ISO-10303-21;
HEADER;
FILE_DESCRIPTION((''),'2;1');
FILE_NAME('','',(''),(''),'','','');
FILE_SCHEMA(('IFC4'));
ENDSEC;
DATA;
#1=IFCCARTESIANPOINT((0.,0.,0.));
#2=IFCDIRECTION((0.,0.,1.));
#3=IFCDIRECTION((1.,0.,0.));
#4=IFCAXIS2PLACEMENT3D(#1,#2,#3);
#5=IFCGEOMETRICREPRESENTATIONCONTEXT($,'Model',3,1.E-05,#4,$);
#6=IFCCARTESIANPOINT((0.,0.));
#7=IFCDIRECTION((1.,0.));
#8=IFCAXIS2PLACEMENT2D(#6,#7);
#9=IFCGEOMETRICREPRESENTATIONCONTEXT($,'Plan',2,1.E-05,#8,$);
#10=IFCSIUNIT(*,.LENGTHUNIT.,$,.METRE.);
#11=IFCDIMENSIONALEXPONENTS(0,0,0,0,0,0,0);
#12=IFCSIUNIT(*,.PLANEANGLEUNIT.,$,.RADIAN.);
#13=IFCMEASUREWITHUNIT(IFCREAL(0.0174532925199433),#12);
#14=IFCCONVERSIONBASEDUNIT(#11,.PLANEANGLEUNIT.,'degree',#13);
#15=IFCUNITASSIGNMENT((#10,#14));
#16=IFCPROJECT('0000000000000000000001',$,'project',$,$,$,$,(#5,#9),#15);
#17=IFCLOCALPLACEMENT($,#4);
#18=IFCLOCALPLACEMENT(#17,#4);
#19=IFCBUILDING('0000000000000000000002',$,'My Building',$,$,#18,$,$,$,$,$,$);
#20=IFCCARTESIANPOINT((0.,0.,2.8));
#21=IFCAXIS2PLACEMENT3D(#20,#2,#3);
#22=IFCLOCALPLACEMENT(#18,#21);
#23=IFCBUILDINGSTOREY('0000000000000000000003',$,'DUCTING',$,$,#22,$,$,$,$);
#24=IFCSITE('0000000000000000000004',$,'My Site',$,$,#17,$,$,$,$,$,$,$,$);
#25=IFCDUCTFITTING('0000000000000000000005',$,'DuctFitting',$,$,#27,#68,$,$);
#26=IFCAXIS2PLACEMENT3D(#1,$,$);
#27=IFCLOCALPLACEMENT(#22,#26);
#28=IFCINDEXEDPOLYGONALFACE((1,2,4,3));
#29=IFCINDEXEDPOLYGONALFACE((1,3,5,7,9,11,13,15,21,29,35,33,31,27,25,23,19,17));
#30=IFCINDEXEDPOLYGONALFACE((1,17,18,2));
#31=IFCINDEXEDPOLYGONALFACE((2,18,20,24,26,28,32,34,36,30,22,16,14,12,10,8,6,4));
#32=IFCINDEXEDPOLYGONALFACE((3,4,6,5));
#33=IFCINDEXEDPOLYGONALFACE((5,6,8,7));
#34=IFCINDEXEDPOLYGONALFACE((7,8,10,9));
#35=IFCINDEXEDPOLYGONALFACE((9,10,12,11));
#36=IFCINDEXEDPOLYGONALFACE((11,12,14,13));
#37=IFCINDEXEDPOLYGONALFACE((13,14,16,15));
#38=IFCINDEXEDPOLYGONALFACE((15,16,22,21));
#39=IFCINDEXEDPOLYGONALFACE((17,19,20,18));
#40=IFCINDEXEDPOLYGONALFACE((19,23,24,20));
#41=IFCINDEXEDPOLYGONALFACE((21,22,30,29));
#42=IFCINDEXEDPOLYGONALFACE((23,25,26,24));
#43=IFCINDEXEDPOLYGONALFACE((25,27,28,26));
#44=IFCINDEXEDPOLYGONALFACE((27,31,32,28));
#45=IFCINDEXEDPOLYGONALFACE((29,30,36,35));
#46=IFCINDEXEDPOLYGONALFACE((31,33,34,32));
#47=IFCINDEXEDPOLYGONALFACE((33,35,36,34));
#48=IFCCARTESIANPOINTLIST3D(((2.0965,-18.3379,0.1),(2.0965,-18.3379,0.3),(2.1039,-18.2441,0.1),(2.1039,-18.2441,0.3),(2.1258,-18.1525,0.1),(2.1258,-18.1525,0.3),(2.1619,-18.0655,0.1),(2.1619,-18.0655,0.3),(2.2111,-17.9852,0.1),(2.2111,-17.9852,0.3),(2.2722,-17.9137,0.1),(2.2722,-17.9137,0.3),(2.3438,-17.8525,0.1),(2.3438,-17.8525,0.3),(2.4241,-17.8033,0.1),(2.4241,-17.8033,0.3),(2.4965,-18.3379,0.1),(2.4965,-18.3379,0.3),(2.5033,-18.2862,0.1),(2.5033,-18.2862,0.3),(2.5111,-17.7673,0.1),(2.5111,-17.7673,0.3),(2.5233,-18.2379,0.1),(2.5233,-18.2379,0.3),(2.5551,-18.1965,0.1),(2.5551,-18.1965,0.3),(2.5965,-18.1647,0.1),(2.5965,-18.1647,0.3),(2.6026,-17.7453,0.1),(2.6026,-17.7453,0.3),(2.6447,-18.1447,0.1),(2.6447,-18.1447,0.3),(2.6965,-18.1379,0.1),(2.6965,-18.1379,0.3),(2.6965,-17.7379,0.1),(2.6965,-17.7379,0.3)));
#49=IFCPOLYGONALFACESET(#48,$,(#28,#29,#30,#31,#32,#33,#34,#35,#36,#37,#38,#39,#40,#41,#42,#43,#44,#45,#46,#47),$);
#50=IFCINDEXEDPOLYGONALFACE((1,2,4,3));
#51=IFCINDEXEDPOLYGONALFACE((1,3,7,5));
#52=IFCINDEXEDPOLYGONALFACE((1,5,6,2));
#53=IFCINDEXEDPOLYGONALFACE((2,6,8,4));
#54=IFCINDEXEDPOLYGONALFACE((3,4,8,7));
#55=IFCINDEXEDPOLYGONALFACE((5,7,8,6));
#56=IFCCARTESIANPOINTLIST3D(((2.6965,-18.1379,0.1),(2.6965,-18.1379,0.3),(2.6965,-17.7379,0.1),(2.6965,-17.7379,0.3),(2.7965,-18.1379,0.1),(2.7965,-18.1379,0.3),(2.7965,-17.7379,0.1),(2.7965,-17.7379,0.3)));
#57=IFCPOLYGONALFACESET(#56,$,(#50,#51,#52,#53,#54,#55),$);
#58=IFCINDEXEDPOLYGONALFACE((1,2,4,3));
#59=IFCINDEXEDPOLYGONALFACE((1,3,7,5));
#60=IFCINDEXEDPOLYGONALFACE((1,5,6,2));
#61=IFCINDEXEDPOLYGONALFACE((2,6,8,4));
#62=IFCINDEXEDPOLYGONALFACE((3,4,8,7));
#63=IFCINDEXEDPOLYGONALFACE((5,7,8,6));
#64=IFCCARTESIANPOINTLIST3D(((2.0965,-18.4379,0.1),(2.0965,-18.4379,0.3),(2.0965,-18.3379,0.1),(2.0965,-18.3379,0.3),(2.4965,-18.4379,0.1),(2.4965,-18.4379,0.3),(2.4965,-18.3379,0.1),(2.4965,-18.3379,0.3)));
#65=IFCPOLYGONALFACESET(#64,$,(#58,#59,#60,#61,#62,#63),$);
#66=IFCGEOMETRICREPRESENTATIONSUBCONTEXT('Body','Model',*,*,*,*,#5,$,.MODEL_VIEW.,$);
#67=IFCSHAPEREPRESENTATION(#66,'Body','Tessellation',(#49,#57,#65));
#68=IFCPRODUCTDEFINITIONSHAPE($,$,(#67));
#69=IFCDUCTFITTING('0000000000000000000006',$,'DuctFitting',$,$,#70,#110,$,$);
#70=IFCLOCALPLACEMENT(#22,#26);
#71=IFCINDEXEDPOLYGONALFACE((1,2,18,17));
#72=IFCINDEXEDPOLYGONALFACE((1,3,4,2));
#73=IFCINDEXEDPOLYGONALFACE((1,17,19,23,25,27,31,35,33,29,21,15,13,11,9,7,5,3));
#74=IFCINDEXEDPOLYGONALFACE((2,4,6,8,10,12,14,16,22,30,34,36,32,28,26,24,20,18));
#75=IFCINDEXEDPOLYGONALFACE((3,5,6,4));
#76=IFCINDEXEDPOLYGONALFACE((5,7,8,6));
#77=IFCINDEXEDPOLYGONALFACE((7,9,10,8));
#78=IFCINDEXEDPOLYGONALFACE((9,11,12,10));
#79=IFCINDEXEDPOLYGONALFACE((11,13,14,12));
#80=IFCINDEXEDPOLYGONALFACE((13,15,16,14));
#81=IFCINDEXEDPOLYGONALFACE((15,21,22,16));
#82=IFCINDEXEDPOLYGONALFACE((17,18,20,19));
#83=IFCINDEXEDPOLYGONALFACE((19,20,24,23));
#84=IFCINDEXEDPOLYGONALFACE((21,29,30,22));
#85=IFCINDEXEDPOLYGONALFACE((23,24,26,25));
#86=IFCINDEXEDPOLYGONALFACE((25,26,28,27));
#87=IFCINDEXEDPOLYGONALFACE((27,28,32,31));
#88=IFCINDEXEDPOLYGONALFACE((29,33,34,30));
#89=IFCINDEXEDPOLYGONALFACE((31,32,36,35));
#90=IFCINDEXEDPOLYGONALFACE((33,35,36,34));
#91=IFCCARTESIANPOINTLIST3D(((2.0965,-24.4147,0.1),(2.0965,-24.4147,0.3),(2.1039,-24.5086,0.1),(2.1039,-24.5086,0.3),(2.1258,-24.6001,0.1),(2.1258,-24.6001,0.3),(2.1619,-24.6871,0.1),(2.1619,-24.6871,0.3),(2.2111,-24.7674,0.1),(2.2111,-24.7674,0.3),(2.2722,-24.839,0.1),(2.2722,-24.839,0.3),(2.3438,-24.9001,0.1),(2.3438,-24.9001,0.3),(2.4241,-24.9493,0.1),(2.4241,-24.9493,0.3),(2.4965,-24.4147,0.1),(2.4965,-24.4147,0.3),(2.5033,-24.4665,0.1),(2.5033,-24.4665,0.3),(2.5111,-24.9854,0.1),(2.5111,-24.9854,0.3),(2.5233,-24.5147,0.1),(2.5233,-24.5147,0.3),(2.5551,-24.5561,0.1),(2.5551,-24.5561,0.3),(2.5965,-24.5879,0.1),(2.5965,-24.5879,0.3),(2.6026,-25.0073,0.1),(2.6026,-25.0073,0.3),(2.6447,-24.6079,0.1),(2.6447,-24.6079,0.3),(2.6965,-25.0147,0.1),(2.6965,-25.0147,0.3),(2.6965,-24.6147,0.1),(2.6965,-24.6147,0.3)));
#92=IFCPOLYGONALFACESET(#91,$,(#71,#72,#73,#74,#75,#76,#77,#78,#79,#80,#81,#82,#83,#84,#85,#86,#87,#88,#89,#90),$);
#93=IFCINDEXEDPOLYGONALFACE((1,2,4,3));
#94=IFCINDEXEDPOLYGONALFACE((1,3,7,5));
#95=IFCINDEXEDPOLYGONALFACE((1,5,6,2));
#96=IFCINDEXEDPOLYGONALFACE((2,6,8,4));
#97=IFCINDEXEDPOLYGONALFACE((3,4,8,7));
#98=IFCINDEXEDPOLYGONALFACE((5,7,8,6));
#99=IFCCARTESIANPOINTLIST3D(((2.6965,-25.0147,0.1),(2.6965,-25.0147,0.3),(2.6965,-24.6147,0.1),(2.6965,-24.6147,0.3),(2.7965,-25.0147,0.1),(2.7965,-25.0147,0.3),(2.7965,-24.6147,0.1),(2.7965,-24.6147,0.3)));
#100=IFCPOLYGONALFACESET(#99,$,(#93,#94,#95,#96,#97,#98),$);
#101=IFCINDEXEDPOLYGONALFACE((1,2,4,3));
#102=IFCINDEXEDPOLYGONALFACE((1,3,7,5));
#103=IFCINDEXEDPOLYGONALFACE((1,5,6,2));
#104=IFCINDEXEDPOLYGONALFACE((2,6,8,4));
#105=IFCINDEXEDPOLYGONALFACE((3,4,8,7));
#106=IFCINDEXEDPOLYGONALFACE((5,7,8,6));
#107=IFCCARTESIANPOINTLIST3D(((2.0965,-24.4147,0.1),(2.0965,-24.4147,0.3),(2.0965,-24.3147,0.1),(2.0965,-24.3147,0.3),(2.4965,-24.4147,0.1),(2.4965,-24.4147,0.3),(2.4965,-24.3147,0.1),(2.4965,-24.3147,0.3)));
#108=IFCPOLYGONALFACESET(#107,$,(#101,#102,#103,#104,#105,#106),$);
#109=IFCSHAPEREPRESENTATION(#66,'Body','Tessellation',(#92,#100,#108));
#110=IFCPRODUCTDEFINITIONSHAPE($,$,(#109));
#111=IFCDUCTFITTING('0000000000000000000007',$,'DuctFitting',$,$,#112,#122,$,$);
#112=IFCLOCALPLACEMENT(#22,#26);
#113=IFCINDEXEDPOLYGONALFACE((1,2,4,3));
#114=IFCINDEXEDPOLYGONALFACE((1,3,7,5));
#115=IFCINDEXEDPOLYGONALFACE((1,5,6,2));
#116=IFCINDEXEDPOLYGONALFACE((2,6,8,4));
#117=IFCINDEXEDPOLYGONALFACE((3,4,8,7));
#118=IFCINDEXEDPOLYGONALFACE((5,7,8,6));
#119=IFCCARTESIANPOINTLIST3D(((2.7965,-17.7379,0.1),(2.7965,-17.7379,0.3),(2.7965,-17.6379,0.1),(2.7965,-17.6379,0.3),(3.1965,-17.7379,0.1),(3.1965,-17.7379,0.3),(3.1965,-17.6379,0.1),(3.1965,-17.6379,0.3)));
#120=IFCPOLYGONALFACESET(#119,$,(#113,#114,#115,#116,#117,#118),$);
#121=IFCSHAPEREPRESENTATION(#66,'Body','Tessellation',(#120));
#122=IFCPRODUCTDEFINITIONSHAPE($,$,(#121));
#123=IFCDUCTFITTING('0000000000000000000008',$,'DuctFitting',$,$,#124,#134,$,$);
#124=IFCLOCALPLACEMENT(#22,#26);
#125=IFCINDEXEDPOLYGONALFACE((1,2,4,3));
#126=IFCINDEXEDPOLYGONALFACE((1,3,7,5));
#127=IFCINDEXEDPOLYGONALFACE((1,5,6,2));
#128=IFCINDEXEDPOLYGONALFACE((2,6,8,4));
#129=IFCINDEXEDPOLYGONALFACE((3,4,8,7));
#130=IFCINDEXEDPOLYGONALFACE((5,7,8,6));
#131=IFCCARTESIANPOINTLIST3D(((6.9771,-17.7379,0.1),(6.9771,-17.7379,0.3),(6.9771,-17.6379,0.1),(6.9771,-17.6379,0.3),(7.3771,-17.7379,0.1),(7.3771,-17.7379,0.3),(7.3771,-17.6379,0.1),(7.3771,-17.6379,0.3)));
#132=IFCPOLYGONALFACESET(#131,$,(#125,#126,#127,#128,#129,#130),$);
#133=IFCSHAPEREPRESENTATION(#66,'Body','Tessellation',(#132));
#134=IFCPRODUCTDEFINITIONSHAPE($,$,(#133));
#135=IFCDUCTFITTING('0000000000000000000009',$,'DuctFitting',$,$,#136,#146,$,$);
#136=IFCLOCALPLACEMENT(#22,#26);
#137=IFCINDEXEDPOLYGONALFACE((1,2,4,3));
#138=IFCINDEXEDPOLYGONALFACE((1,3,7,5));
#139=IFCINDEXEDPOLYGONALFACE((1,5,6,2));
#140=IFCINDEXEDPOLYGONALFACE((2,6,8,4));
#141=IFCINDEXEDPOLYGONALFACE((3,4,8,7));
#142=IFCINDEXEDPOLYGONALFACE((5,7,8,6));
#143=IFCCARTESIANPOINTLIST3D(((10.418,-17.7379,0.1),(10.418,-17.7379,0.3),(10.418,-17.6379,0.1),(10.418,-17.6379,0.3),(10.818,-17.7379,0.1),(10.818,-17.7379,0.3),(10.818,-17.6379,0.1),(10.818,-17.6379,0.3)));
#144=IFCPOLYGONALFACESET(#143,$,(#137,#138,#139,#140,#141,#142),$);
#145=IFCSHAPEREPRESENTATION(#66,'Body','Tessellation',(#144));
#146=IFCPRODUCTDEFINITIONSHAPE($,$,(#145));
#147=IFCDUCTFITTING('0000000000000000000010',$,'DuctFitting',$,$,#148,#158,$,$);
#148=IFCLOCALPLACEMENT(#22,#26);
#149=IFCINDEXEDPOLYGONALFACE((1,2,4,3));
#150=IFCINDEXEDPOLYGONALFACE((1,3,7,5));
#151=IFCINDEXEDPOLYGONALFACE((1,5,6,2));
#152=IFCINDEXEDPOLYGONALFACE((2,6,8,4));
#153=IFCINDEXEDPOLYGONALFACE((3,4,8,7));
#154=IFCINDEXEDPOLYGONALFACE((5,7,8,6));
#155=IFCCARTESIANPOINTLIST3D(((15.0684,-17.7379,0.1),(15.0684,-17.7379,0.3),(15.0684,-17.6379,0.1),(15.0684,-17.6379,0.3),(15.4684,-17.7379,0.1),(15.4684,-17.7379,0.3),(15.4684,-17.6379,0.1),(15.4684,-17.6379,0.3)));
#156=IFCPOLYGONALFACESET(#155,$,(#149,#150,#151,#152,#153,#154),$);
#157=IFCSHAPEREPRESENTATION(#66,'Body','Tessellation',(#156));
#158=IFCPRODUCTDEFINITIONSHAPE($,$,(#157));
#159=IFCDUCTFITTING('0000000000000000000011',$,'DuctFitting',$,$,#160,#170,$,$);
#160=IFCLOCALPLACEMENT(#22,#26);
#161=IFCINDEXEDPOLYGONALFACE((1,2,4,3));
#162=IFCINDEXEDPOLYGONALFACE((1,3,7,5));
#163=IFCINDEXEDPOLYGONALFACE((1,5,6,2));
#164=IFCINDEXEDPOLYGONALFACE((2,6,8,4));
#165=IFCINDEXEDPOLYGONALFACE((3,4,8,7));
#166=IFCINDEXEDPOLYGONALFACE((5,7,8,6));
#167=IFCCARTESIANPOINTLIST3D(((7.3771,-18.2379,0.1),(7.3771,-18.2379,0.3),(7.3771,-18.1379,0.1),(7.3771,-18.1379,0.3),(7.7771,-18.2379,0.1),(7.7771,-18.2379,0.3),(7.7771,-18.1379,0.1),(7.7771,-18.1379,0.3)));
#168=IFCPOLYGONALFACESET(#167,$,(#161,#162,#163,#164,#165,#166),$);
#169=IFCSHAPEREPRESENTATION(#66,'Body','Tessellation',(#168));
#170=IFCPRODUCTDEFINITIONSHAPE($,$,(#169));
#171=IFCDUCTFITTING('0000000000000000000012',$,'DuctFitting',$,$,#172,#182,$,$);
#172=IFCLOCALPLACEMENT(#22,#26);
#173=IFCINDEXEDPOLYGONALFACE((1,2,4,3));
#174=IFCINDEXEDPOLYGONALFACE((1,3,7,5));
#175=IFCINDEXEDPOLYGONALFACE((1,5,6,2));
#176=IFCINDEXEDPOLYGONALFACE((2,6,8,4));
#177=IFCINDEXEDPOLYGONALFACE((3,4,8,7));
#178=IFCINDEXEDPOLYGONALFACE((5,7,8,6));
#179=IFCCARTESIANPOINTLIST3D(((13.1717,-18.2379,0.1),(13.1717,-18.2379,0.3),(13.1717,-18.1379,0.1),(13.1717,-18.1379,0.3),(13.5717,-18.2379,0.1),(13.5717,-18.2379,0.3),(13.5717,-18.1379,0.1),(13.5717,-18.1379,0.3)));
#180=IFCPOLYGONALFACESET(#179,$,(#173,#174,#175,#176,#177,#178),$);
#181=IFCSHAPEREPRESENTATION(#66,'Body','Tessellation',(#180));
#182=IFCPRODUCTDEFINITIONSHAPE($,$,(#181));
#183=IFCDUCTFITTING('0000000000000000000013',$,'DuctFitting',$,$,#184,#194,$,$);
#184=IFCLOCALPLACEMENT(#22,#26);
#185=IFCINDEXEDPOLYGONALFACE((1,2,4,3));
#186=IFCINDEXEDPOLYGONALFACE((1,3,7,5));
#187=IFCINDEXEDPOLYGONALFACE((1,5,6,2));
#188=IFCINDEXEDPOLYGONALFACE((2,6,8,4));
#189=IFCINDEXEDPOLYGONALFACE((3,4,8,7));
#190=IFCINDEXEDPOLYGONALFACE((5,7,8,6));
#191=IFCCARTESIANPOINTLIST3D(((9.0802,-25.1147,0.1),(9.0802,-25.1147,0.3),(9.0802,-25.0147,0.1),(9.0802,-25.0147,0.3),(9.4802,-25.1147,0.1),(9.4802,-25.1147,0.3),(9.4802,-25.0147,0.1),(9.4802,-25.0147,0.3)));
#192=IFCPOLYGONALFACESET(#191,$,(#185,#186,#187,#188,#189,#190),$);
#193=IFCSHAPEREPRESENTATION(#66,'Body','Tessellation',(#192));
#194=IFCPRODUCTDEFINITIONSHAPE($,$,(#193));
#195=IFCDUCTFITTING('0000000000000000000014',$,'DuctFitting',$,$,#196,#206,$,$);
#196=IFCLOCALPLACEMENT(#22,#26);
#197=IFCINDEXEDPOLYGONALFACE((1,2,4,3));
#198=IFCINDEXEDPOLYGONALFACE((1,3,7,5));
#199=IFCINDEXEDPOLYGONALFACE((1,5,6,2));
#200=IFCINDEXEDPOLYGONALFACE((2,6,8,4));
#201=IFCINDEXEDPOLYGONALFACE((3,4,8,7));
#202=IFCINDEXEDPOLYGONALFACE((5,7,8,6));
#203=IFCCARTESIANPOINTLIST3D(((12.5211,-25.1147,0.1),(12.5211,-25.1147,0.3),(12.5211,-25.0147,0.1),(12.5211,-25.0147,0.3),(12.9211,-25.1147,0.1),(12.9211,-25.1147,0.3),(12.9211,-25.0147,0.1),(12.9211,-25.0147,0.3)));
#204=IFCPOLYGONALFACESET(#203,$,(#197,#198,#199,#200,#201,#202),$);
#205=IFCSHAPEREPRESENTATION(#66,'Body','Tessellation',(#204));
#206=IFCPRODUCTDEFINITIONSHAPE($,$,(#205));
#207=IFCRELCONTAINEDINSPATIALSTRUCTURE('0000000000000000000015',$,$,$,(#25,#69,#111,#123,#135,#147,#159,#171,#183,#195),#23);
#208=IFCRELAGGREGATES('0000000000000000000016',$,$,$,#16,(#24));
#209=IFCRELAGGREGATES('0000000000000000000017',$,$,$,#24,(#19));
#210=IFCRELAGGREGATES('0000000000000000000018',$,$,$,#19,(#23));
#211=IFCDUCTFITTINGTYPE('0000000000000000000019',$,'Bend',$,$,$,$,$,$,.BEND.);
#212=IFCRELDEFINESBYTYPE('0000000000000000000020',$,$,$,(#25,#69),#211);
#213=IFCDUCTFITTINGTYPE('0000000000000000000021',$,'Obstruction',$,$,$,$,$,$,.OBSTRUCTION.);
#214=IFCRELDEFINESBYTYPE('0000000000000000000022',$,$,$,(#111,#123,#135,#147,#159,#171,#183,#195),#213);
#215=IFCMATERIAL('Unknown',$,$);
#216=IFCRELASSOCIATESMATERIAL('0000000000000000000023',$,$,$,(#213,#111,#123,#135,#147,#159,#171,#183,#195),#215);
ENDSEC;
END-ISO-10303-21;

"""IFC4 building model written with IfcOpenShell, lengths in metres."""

from ifc_helpers import new_model, entity, si_unit, converted_unit, frame, origin_with_axes, origin_2d_with_axis, place, context, subcontext, project, spatial, line, arc, indexed_curve, rectangle, outline, extrude, source, transform, mapped, material, material_profile, profile_set, profile_usage, type_object, type_shapes, element, save


model = new_model("IFC4")

# Units and contexts
model_context = context("Model", 3, precision=1e-05, world=origin_with_axes())
plan_context = context("Plan", 2, precision=1e-05, world=origin_2d_with_axis())
body_context = subcontext(model_context, "Body", "Model", "MODEL_VIEW")
ifc_project = project(units=[si_unit("LENGTHUNIT", "METRE"), converted_unit("PLANEANGLEUNIT", "degree", entity("IfcReal", 0.0174532925199433), si_unit("PLANEANGLEUNIT", "RADIAN"), dimensions=[0, 0, 0, 0, 0, 0, 0])], contexts=[model_context, plan_context])

# Site, building, storey
site_placement = place(None, origin_with_axes())
site = spatial("IfcSite", under=ifc_project, at=site_placement, Name="My Site")
building_placement = place(site_placement, origin_with_axes())
building = spatial("IfcBuilding", under=site, at=building_placement, Name="My Building")
storey_placement = place(building_placement, frame((0.0, 0.0, 2.8), z_axis=(0.0, 0.0, 1.0), x_axis=(1.0, 0.0, 0.0)))
storey = spatial("IfcBuildingStorey", under=building, at=storey_placement, Name="DUCTING")

# Shared definitions
ifc_material = material(Name="Unknown")

# Duct fittings
duct_fitting_type_1 = type_object("IfcDuctFittingType", Name="Bend", PredefinedType="BEND")
shared_shape = source(origin_with_axes(), body_context, "Body", "SweptSolid", [
    extrude(outline(indexed_curve([(-0.2, 0.0), (-0.2586, -0.1414), (-0.4, -0.2), (-0.4, -0.6), (0.0243, -0.4243), (0.2, 0.0)], segments=[arc(1, 2, 3), line(3, 4), arc(4, 5, 6), line(6, 1)])), frame((0.0, -0.1, -0.1), z_axis=(0.0, -1.0, 0.0), x_axis=(1.0, 0.0, 0.0)), (0.0, 0.0, -1.0), 0.2),
    extrude(rectangle(XDim=0.4, YDim=0.2), origin_with_axes(), (0.0, 0.0, -1.0), 0.1),
    extrude(rectangle(XDim=0.4, YDim=0.2), frame((-0.4, 0.0, -0.5), z_axis=(-1.0, 0.0, 0.0), x_axis=(0.0, 0.0, -1.0)), (0.0, 0.0, 1.0), 0.1),
])
type_shapes(duct_fitting_type_1, [shared_shape])
for number, where, z_axis, x_axis, name in (
    (1, (2.7965, -17.9379, 0.2), (1.0, 0.0, 0.0), (0.0, 1.0, 0.0), "DuctFitting"),
    (2, (2.7965, -24.8147, 0.2), (1.0, 0.0, 0.0), (0.0, -1.0, 0.0), "DuctFitting"),
):
    element("IfcDuctFitting", number, at=place(storey_placement, frame(where, z_axis=z_axis, x_axis=x_axis)), inside=storey, type_object=duct_fitting_type_1, Name=name, context=body_context, shape_type="MappedRepresentation", body=[
        mapped(shared_shape, transform((0.0, 0.0, 0.0), x_axis=(1.0, 0.0, 0.0), y_axis=(0.0, 1.0, 0.0), z_axis=(0.0, 0.0, 1.0), scale=1.0)),
    ])
ifc_material_profile_1 = material_profile(ifc_material, rectangle(XDim=0.4, YDim=0.2))
ifc_profile_set_1 = profile_set([ifc_material_profile_1])
ifc_profile_usage_1 = profile_usage(ifc_profile_set_1, cardinal=5)
duct_fitting_type_2 = type_object("IfcDuctFittingType", Name="Obstruction", PredefinedType="OBSTRUCTION", material=ifc_profile_set_1)
duct_fitting_1_placement = place(storey_placement, frame((2.9965, -17.7379, 0.2), z_axis=(0.0, 1.0, 0.0), x_axis=(-1.0, 0.0, 0.0)))
element("IfcDuctFitting", 3, at=duct_fitting_1_placement, inside=storey, type_object=duct_fitting_type_2, material=ifc_profile_usage_1, Name="DuctFitting", context=body_context, shape_type="SweptSolid", body=[
    extrude(rectangle(XDim=0.4, YDim=0.2), origin_with_axes(), (0.0, 0.0, 1.0), 0.1),
])
ifc_profile_usage_2 = profile_usage(ifc_profile_set_1, cardinal=5)
duct_fitting_2_placement = place(storey_placement, frame((7.1771, -17.7379, 0.2), z_axis=(0.0, 1.0, 0.0), x_axis=(-1.0, 0.0, 0.0)))
element("IfcDuctFitting", 4, at=duct_fitting_2_placement, inside=storey, type_object=duct_fitting_type_2, material=ifc_profile_usage_2, Name="DuctFitting", context=body_context, shape_type="SweptSolid", body=[
    extrude(rectangle(XDim=0.4, YDim=0.2), origin_with_axes(), (0.0, 0.0, 1.0), 0.1),
])
ifc_profile_usage_3 = profile_usage(ifc_profile_set_1, cardinal=5)
duct_fitting_3_placement = place(storey_placement, frame((10.618, -17.7379, 0.2), z_axis=(0.0, 1.0, 0.0), x_axis=(-1.0, 0.0, 0.0)))
element("IfcDuctFitting", 5, at=duct_fitting_3_placement, inside=storey, type_object=duct_fitting_type_2, material=ifc_profile_usage_3, Name="DuctFitting", context=body_context, shape_type="SweptSolid", body=[
    extrude(rectangle(XDim=0.4, YDim=0.2), origin_with_axes(), (0.0, 0.0, 1.0), 0.1),
])
ifc_profile_usage_4 = profile_usage(ifc_profile_set_1, cardinal=5)
duct_fitting_4_placement = place(storey_placement, frame((15.2684, -17.7379, 0.2), z_axis=(0.0, 1.0, 0.0), x_axis=(-1.0, 0.0, 0.0)))
element("IfcDuctFitting", 6, at=duct_fitting_4_placement, inside=storey, type_object=duct_fitting_type_2, material=ifc_profile_usage_4, Name="DuctFitting", context=body_context, shape_type="SweptSolid", body=[
    extrude(rectangle(XDim=0.4, YDim=0.2), origin_with_axes(), (0.0, 0.0, 1.0), 0.1),
])
ifc_profile_usage_5 = profile_usage(ifc_profile_set_1, cardinal=5)
duct_fitting_5_placement = place(storey_placement, frame((7.5771, -18.1379, 0.2), z_axis=(0.0, -1.0, 0.0), x_axis=(1.0, 0.0, 0.0)))
element("IfcDuctFitting", 7, at=duct_fitting_5_placement, inside=storey, type_object=duct_fitting_type_2, material=ifc_profile_usage_5, Name="DuctFitting", context=body_context, shape_type="SweptSolid", body=[
    extrude(rectangle(XDim=0.4, YDim=0.2), origin_with_axes(), (0.0, 0.0, 1.0), 0.1),
])
ifc_profile_usage_6 = profile_usage(ifc_profile_set_1, cardinal=5)
duct_fitting_6_placement = place(storey_placement, frame((13.3717, -18.1379, 0.2), z_axis=(0.0, -1.0, 0.0), x_axis=(1.0, 0.0, 0.0)))
element("IfcDuctFitting", 8, at=duct_fitting_6_placement, inside=storey, type_object=duct_fitting_type_2, material=ifc_profile_usage_6, Name="DuctFitting", context=body_context, shape_type="SweptSolid", body=[
    extrude(rectangle(XDim=0.4, YDim=0.2), origin_with_axes(), (0.0, 0.0, 1.0), 0.1),
])
ifc_profile_usage_7 = profile_usage(ifc_profile_set_1, cardinal=5)
duct_fitting_7_placement = place(storey_placement, frame((9.2802, -25.0147, 0.2), z_axis=(0.0, -1.0, 0.0), x_axis=(1.0, 0.0, 0.0)))
element("IfcDuctFitting", 9, at=duct_fitting_7_placement, inside=storey, type_object=duct_fitting_type_2, material=ifc_profile_usage_7, Name="DuctFitting", context=body_context, shape_type="SweptSolid", body=[
    extrude(rectangle(XDim=0.4, YDim=0.2), origin_with_axes(), (0.0, 0.0, 1.0), 0.1),
])
ifc_profile_usage_8 = profile_usage(ifc_profile_set_1, cardinal=5)
duct_fitting_8_placement = place(storey_placement, frame((12.7211, -25.0147, 0.2), z_axis=(0.0, -1.0, 0.0), x_axis=(1.0, 0.0, 0.0)))
element("IfcDuctFitting", 10, at=duct_fitting_8_placement, inside=storey, type_object=duct_fitting_type_2, material=ifc_profile_usage_8, Name="DuctFitting", context=body_context, shape_type="SweptSolid", body=[
    extrude(rectangle(XDim=0.4, YDim=0.2), origin_with_axes(), (0.0, 0.0, 1.0), 0.1),
])

save(model, "model.ifc")
